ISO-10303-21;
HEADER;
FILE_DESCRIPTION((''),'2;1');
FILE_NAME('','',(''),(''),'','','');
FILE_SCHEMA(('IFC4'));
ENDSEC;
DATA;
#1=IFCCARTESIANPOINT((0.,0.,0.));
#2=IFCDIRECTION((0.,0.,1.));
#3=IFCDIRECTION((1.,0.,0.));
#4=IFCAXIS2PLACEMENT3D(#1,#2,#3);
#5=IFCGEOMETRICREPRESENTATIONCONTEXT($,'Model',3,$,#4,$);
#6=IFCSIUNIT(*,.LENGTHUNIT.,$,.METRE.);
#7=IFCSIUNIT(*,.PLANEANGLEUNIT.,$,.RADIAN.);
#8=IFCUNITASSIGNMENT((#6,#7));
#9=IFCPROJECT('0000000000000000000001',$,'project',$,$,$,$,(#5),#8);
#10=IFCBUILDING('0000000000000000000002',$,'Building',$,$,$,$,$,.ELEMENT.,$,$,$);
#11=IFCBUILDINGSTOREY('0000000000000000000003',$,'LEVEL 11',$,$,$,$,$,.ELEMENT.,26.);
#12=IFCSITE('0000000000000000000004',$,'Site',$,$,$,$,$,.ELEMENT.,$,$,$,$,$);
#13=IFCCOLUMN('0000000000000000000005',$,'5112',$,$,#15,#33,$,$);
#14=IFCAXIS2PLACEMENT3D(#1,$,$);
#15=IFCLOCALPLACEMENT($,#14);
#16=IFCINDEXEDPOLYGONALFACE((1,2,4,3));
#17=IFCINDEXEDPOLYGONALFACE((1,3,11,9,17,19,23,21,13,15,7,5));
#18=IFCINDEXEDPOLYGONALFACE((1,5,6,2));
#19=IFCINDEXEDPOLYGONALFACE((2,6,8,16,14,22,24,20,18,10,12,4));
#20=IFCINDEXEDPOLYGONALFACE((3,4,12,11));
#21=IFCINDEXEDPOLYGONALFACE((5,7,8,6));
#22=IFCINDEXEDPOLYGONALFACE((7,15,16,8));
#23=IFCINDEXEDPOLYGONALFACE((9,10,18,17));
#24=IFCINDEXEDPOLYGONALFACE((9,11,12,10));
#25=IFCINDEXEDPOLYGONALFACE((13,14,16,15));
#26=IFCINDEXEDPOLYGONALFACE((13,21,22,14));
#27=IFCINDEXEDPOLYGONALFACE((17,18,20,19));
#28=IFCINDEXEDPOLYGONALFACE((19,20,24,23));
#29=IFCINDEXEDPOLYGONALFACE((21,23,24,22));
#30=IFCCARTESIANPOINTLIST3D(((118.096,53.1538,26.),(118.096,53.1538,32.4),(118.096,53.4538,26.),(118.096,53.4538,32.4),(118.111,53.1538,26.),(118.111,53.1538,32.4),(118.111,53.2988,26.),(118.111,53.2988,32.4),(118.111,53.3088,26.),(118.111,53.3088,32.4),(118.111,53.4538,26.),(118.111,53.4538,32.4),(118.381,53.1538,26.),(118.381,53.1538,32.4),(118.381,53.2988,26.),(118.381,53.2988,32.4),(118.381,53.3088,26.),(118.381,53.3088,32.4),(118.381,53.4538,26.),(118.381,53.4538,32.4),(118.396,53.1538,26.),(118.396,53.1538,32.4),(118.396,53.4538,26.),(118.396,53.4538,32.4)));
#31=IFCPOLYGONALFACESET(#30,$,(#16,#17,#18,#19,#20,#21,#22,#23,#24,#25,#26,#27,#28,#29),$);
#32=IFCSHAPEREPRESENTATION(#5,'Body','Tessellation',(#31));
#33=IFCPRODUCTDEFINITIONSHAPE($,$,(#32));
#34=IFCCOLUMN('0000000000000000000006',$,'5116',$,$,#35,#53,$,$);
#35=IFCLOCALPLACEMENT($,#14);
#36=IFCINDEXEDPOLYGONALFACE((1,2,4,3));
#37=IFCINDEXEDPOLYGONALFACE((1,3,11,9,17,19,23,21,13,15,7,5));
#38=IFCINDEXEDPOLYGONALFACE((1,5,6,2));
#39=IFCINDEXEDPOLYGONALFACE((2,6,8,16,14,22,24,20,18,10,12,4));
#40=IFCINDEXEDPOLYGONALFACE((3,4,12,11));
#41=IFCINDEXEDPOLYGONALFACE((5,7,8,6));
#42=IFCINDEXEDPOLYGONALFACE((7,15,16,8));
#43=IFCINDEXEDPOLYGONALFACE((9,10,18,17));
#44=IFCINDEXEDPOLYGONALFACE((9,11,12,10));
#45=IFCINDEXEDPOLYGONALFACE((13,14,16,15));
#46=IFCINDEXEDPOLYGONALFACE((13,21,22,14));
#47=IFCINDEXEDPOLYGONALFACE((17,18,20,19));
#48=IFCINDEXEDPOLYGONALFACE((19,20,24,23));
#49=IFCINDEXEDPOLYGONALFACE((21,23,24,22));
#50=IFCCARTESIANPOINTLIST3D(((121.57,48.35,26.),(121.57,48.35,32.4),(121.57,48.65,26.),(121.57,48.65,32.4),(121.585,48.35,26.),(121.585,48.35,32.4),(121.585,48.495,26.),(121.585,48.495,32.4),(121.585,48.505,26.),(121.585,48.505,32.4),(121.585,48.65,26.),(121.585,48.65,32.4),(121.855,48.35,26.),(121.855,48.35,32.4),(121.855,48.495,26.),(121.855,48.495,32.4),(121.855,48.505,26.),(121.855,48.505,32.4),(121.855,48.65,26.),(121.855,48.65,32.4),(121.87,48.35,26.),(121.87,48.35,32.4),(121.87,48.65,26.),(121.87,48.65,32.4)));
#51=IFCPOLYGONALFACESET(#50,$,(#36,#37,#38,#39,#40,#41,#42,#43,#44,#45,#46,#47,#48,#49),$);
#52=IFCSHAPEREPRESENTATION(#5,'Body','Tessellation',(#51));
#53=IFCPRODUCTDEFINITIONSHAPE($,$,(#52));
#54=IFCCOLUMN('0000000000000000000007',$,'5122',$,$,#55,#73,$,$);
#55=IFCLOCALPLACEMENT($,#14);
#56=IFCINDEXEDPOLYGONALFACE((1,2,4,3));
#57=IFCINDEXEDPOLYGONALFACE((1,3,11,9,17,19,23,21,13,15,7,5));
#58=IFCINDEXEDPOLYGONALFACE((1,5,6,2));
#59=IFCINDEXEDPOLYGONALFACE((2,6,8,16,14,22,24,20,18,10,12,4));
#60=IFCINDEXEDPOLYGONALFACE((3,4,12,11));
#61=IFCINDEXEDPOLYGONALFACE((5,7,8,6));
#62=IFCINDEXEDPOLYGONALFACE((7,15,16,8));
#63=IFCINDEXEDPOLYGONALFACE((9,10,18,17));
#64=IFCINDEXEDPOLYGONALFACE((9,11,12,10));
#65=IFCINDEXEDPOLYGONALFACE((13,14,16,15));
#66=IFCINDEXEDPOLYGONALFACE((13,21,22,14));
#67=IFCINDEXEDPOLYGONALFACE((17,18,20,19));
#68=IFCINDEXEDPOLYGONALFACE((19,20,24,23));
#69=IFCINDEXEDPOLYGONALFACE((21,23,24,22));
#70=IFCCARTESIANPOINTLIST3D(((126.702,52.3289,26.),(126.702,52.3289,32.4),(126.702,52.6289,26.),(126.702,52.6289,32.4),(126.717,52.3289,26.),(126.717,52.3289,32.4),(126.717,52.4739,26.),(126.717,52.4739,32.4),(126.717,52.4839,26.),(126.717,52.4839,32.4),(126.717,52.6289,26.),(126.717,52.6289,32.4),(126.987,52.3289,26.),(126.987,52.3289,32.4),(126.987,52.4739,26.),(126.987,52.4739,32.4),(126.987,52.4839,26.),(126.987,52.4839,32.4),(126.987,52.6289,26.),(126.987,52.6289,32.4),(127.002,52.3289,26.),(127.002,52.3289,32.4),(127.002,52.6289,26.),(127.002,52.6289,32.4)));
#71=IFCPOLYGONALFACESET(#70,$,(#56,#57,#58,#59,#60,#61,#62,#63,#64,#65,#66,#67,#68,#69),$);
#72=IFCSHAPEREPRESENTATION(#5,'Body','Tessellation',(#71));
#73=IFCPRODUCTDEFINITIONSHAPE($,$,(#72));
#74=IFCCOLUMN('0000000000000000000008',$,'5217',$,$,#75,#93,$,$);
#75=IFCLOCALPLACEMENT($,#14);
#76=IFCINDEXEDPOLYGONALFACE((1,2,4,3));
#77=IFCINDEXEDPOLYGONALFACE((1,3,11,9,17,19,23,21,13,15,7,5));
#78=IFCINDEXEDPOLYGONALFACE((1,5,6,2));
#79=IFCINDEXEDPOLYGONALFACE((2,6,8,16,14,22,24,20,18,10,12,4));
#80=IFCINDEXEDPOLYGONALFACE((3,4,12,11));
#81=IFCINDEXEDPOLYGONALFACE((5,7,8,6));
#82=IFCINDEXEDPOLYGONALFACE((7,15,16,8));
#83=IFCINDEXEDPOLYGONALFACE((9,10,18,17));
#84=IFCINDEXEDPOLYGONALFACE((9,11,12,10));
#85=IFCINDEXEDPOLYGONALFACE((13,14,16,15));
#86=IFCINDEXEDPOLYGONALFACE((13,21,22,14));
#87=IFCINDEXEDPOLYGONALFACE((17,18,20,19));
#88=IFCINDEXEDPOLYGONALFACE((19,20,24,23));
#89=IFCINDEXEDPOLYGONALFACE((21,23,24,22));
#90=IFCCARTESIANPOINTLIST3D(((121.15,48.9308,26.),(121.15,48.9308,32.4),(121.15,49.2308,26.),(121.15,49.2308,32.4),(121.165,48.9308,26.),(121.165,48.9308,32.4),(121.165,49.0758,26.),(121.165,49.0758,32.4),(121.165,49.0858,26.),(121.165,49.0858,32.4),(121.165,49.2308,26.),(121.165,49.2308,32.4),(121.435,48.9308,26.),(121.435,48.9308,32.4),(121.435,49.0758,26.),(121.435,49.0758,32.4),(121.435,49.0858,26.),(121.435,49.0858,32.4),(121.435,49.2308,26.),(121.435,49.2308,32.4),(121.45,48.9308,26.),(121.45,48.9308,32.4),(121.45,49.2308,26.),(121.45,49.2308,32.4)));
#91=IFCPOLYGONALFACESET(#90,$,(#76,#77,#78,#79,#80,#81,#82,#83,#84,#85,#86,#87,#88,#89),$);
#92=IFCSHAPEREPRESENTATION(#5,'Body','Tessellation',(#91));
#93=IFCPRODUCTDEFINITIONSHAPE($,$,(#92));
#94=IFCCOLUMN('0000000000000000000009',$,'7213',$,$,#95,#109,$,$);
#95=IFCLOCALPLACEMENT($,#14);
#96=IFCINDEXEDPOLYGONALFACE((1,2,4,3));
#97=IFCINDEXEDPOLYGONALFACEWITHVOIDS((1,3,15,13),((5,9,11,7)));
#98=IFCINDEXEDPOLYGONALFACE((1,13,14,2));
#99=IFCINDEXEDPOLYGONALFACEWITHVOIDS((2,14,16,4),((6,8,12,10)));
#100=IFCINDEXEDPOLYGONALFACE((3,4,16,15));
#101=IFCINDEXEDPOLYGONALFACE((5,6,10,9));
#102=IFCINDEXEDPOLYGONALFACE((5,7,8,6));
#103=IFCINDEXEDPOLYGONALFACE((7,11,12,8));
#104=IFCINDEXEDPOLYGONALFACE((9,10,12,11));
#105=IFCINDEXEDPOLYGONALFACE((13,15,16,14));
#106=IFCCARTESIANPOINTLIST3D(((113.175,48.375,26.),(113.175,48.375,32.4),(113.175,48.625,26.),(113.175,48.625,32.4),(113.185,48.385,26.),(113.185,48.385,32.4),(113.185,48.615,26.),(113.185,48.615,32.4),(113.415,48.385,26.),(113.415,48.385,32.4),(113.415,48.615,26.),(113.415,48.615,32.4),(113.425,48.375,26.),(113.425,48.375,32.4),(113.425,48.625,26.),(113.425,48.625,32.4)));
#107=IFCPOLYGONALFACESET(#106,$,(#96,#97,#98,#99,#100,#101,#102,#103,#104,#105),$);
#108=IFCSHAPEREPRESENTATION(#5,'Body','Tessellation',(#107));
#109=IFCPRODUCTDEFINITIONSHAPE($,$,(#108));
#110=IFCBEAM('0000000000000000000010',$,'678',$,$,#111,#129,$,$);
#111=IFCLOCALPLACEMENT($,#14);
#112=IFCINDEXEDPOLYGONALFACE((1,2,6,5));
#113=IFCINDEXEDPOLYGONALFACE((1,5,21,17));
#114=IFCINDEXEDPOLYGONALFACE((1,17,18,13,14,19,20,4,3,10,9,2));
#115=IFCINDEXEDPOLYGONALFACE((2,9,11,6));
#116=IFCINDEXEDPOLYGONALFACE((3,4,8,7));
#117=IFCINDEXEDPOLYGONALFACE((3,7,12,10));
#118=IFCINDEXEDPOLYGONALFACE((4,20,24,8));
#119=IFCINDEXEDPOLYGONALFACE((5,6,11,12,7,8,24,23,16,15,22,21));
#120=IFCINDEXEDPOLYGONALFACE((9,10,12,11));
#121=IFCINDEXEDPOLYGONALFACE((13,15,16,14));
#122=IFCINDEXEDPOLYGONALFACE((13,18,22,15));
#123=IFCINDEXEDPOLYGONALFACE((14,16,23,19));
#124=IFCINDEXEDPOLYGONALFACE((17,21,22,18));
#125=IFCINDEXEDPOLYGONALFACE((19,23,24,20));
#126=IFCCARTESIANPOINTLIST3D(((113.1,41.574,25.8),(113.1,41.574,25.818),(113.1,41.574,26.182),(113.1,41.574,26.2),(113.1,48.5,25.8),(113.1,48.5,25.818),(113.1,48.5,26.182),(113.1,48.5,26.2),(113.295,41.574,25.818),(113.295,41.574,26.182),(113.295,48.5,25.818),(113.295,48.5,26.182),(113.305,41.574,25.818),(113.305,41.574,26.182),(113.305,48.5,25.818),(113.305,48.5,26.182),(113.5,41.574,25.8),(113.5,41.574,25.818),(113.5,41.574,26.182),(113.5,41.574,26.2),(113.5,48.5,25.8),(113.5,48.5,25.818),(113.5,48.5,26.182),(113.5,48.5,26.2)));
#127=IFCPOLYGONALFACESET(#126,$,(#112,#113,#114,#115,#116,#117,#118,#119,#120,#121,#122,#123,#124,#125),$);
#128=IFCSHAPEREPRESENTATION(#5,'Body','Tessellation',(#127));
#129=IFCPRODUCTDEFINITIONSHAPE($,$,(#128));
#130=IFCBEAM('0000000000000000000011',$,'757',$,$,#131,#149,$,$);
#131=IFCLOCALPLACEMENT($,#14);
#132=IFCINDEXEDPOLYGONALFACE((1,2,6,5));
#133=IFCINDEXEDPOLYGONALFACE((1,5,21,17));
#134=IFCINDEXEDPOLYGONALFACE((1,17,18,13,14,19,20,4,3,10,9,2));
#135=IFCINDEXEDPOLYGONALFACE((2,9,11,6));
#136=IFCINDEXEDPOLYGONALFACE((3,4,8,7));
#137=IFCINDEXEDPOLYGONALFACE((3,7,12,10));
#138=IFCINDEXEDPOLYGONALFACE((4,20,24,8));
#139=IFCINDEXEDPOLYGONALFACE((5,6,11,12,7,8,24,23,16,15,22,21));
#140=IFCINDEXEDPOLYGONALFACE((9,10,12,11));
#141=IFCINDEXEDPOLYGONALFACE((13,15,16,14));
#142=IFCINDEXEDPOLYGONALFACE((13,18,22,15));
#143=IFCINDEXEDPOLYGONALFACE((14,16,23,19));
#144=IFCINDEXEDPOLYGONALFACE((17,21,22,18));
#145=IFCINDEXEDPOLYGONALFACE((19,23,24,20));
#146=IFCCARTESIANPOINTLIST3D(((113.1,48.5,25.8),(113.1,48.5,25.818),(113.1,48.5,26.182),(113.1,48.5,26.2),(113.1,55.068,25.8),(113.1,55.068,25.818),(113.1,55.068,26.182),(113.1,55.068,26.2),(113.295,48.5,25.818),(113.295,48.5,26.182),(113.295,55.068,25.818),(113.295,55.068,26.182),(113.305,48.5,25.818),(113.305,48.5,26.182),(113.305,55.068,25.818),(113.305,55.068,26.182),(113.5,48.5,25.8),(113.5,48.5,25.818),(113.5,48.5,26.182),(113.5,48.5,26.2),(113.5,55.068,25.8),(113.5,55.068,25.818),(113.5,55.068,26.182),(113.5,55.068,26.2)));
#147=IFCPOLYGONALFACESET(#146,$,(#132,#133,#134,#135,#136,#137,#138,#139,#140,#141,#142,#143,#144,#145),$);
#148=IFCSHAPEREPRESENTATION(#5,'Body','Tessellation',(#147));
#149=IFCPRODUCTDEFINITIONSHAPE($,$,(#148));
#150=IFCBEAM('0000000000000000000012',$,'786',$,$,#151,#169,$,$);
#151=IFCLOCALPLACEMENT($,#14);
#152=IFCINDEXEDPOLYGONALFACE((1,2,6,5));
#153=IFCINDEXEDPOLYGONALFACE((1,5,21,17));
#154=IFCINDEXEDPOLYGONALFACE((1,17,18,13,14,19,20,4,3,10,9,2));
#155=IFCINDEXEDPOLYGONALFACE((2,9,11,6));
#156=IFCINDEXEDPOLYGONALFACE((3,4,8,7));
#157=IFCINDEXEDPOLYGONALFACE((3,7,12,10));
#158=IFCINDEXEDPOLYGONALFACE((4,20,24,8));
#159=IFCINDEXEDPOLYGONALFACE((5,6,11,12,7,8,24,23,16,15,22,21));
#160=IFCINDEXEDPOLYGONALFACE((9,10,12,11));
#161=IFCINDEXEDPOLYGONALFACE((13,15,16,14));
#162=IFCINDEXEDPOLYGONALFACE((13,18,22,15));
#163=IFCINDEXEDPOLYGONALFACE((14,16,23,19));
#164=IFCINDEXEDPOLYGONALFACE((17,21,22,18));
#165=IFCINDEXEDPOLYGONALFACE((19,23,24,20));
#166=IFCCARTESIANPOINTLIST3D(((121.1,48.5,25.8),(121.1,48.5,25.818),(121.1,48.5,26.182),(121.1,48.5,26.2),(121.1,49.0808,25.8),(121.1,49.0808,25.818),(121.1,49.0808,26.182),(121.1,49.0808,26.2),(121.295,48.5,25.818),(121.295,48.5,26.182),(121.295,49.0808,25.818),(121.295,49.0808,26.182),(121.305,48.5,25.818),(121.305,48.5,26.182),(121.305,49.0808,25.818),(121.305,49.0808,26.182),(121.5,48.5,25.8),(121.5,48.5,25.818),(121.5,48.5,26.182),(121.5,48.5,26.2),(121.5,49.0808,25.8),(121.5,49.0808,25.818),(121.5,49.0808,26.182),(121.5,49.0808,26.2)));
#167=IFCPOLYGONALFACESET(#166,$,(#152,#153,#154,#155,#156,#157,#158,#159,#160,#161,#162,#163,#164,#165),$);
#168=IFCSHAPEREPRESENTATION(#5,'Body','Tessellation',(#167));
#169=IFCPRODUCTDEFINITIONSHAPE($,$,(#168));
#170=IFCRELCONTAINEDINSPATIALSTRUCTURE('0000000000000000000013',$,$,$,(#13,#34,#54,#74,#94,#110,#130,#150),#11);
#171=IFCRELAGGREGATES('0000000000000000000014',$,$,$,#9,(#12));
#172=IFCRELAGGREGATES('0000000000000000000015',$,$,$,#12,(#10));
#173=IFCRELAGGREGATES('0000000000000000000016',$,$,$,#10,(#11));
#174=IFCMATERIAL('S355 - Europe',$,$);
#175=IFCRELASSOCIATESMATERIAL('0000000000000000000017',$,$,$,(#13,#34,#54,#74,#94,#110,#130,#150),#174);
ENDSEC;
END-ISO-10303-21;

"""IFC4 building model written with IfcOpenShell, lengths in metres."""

from ifc_helpers import new_model, si_unit, frame, origin_with_axes, origin_2d_with_axis, place, context, project, spatial, hollow_rectangle, i_section, extrude, material, material_profile, profile_set, profile_usage, element, save


model = new_model("IFC4")

# Units and contexts
model_context = context("Model", 3, world=origin_with_axes())
ifc_project = project(units=[si_unit("LENGTHUNIT", "METRE"), si_unit("PLANEANGLEUNIT", "RADIAN")], contexts=[model_context])

# Site, building, storey
site = spatial("IfcSite", under=ifc_project, Name="Site", CompositionType="ELEMENT")
building = spatial("IfcBuilding", under=site, Name="Building", CompositionType="ELEMENT")
storey = spatial("IfcBuildingStorey", under=building, Name="LEVEL 11", CompositionType="ELEMENT", Elevation=26.0)

# Columns
ifc_material = material(Name="S355 - Europe")
ifc_material_profile_1 = material_profile(ifc_material, i_section(OverallWidth=0.3, OverallDepth=0.3, WebThickness=0.01, FlangeThickness=0.015, at=origin_2d_with_axis()))
ifc_profile_set_1 = profile_set([ifc_material_profile_1])
ifc_profile_usage_1 = profile_usage(ifc_profile_set_1, cardinal=10)
column_1_placement = place(None, frame((118.246, 53.3038, 26.0), z_axis=(0.0, 0.0, 1.0), x_axis=(0.0, -1.0, 0.0)))
element("IfcColumn", 1, at=column_1_placement, inside=storey, material=ifc_profile_usage_1, Name="5112", context=model_context, shape_type="SweptSolid", body=[
    extrude(i_section(OverallWidth=0.3, OverallDepth=0.3, WebThickness=0.01, FlangeThickness=0.015, at=origin_2d_with_axis()), origin_with_axes(), (0.0, 0.0, 1.0), 6.4),
])
ifc_material_profile_2 = material_profile(ifc_material, i_section(OverallWidth=0.3, OverallDepth=0.3, WebThickness=0.01, FlangeThickness=0.015, at=origin_2d_with_axis()))
ifc_profile_set_2 = profile_set([ifc_material_profile_2])
ifc_profile_usage_2 = profile_usage(ifc_profile_set_2, cardinal=10)
column_2_placement = place(None, frame((121.72, 48.5, 26.0), z_axis=(0.0, 0.0, 1.0), x_axis=(0.0, -1.0, 0.0)))
element("IfcColumn", 2, at=column_2_placement, inside=storey, material=ifc_profile_usage_2, Name="5116", context=model_context, shape_type="SweptSolid", body=[
    extrude(i_section(OverallWidth=0.3, OverallDepth=0.3, WebThickness=0.01, FlangeThickness=0.015, at=origin_2d_with_axis()), origin_with_axes(), (0.0, 0.0, 1.0), 6.4),
])
ifc_material_profile_3 = material_profile(ifc_material, i_section(OverallWidth=0.3, OverallDepth=0.3, WebThickness=0.01, FlangeThickness=0.015, at=origin_2d_with_axis()))
ifc_profile_set_3 = profile_set([ifc_material_profile_3])
ifc_profile_usage_3 = profile_usage(ifc_profile_set_3, cardinal=10)
column_3_placement = place(None, frame((126.852, 52.4789, 26.0), z_axis=(0.0, 0.0, 1.0), x_axis=(0.0, -1.0, 0.0)))
element("IfcColumn", 3, at=column_3_placement, inside=storey, material=ifc_profile_usage_3, Name="5122", context=model_context, shape_type="SweptSolid", body=[
    extrude(i_section(OverallWidth=0.3, OverallDepth=0.3, WebThickness=0.01, FlangeThickness=0.015, at=origin_2d_with_axis()), origin_with_axes(), (0.0, 0.0, 1.0), 6.4),
])
ifc_material_profile_4 = material_profile(ifc_material, i_section(OverallWidth=0.3, OverallDepth=0.3, WebThickness=0.01, FlangeThickness=0.015, at=origin_2d_with_axis()))
ifc_profile_set_4 = profile_set([ifc_material_profile_4])
ifc_profile_usage_4 = profile_usage(ifc_profile_set_4, cardinal=10)
column_4_placement = place(None, frame((121.3, 49.0808, 32.4), z_axis=(0.0, 0.0, -1.0), x_axis=(0.0, 1.0, 0.0)))
element("IfcColumn", 4, at=column_4_placement, inside=storey, material=ifc_profile_usage_4, Name="5217", context=model_context, shape_type="SweptSolid", body=[
    extrude(i_section(OverallWidth=0.3, OverallDepth=0.3, WebThickness=0.01, FlangeThickness=0.015, at=origin_2d_with_axis()), origin_with_axes(), (0.0, 0.0, 1.0), 6.4),
])
ifc_material_profile_5 = material_profile(ifc_material, hollow_rectangle(XDim=0.25, YDim=0.25, WallThickness=0.01, at=origin_2d_with_axis()))
ifc_profile_set_5 = profile_set([ifc_material_profile_5])
ifc_profile_usage_5 = profile_usage(ifc_profile_set_5, cardinal=10)
column_5_placement = place(None, frame((113.3, 48.5, 26.0), z_axis=(0.0, 0.0, 1.0), x_axis=(0.0, -1.0, 0.0)))
element("IfcColumn", 5, at=column_5_placement, inside=storey, material=ifc_profile_usage_5, Name="7213", context=model_context, shape_type="SweptSolid", body=[
    extrude(hollow_rectangle(XDim=0.25, YDim=0.25, WallThickness=0.01, at=origin_2d_with_axis()), origin_with_axes(), (0.0, 0.0, 1.0), 6.4),
])

# Beams
ifc_material_profile_6 = material_profile(ifc_material, i_section(OverallWidth=0.4, OverallDepth=0.4, WebThickness=0.01, FlangeThickness=0.018, at=origin_2d_with_axis()))
ifc_profile_set_6 = profile_set([ifc_material_profile_6])
ifc_profile_usage_6 = profile_usage(ifc_profile_set_6, cardinal=10)
beam_1_placement = place(None, frame((113.3, 48.5, 26.0), z_axis=(0.0, -1.0, 0.0), x_axis=(1.0, 0.0, 0.0)))
element("IfcBeam", 6, at=beam_1_placement, inside=storey, material=ifc_profile_usage_6, Name="678", context=model_context, shape_type="SweptSolid", body=[
    extrude(i_section(OverallWidth=0.4, OverallDepth=0.4, WebThickness=0.01, FlangeThickness=0.018, at=origin_2d_with_axis()), origin_with_axes(), (0.0, 0.0, 1.0), 6.926),
])
ifc_material_profile_7 = material_profile(ifc_material, i_section(OverallWidth=0.4, OverallDepth=0.4, WebThickness=0.01, FlangeThickness=0.018, at=origin_2d_with_axis()))
ifc_profile_set_7 = profile_set([ifc_material_profile_7])
ifc_profile_usage_7 = profile_usage(ifc_profile_set_7, cardinal=10)
beam_2_placement = place(None, frame((113.3, 55.068, 26.0), z_axis=(0.0, -1.0, 0.0), x_axis=(1.0, 0.0, 0.0)))
element("IfcBeam", 7, at=beam_2_placement, inside=storey, material=ifc_profile_usage_7, Name="757", context=model_context, shape_type="SweptSolid", body=[
    extrude(i_section(OverallWidth=0.4, OverallDepth=0.4, WebThickness=0.01, FlangeThickness=0.018, at=origin_2d_with_axis()), origin_with_axes(), (0.0, 0.0, 1.0), 6.568),
])
ifc_material_profile_8 = material_profile(ifc_material, i_section(OverallWidth=0.4, OverallDepth=0.4, WebThickness=0.01, FlangeThickness=0.018, at=origin_2d_with_axis()))
ifc_profile_set_8 = profile_set([ifc_material_profile_8])
ifc_profile_usage_8 = profile_usage(ifc_profile_set_8, cardinal=10)
beam_3_placement = place(None, frame((121.3, 48.5, 26.0), z_axis=(0.0, 1.0, 0.0), x_axis=(-1.0, 0.0, 0.0)))
element("IfcBeam", 8, at=beam_3_placement, inside=storey, material=ifc_profile_usage_8, Name="786", context=model_context, shape_type="SweptSolid", body=[
    extrude(i_section(OverallWidth=0.4, OverallDepth=0.4, WebThickness=0.01, FlangeThickness=0.018, at=origin_2d_with_axis()), origin_with_axes(), (0.0, 0.0, 1.0), 0.5808),
])

save(model, "model.ifc")
